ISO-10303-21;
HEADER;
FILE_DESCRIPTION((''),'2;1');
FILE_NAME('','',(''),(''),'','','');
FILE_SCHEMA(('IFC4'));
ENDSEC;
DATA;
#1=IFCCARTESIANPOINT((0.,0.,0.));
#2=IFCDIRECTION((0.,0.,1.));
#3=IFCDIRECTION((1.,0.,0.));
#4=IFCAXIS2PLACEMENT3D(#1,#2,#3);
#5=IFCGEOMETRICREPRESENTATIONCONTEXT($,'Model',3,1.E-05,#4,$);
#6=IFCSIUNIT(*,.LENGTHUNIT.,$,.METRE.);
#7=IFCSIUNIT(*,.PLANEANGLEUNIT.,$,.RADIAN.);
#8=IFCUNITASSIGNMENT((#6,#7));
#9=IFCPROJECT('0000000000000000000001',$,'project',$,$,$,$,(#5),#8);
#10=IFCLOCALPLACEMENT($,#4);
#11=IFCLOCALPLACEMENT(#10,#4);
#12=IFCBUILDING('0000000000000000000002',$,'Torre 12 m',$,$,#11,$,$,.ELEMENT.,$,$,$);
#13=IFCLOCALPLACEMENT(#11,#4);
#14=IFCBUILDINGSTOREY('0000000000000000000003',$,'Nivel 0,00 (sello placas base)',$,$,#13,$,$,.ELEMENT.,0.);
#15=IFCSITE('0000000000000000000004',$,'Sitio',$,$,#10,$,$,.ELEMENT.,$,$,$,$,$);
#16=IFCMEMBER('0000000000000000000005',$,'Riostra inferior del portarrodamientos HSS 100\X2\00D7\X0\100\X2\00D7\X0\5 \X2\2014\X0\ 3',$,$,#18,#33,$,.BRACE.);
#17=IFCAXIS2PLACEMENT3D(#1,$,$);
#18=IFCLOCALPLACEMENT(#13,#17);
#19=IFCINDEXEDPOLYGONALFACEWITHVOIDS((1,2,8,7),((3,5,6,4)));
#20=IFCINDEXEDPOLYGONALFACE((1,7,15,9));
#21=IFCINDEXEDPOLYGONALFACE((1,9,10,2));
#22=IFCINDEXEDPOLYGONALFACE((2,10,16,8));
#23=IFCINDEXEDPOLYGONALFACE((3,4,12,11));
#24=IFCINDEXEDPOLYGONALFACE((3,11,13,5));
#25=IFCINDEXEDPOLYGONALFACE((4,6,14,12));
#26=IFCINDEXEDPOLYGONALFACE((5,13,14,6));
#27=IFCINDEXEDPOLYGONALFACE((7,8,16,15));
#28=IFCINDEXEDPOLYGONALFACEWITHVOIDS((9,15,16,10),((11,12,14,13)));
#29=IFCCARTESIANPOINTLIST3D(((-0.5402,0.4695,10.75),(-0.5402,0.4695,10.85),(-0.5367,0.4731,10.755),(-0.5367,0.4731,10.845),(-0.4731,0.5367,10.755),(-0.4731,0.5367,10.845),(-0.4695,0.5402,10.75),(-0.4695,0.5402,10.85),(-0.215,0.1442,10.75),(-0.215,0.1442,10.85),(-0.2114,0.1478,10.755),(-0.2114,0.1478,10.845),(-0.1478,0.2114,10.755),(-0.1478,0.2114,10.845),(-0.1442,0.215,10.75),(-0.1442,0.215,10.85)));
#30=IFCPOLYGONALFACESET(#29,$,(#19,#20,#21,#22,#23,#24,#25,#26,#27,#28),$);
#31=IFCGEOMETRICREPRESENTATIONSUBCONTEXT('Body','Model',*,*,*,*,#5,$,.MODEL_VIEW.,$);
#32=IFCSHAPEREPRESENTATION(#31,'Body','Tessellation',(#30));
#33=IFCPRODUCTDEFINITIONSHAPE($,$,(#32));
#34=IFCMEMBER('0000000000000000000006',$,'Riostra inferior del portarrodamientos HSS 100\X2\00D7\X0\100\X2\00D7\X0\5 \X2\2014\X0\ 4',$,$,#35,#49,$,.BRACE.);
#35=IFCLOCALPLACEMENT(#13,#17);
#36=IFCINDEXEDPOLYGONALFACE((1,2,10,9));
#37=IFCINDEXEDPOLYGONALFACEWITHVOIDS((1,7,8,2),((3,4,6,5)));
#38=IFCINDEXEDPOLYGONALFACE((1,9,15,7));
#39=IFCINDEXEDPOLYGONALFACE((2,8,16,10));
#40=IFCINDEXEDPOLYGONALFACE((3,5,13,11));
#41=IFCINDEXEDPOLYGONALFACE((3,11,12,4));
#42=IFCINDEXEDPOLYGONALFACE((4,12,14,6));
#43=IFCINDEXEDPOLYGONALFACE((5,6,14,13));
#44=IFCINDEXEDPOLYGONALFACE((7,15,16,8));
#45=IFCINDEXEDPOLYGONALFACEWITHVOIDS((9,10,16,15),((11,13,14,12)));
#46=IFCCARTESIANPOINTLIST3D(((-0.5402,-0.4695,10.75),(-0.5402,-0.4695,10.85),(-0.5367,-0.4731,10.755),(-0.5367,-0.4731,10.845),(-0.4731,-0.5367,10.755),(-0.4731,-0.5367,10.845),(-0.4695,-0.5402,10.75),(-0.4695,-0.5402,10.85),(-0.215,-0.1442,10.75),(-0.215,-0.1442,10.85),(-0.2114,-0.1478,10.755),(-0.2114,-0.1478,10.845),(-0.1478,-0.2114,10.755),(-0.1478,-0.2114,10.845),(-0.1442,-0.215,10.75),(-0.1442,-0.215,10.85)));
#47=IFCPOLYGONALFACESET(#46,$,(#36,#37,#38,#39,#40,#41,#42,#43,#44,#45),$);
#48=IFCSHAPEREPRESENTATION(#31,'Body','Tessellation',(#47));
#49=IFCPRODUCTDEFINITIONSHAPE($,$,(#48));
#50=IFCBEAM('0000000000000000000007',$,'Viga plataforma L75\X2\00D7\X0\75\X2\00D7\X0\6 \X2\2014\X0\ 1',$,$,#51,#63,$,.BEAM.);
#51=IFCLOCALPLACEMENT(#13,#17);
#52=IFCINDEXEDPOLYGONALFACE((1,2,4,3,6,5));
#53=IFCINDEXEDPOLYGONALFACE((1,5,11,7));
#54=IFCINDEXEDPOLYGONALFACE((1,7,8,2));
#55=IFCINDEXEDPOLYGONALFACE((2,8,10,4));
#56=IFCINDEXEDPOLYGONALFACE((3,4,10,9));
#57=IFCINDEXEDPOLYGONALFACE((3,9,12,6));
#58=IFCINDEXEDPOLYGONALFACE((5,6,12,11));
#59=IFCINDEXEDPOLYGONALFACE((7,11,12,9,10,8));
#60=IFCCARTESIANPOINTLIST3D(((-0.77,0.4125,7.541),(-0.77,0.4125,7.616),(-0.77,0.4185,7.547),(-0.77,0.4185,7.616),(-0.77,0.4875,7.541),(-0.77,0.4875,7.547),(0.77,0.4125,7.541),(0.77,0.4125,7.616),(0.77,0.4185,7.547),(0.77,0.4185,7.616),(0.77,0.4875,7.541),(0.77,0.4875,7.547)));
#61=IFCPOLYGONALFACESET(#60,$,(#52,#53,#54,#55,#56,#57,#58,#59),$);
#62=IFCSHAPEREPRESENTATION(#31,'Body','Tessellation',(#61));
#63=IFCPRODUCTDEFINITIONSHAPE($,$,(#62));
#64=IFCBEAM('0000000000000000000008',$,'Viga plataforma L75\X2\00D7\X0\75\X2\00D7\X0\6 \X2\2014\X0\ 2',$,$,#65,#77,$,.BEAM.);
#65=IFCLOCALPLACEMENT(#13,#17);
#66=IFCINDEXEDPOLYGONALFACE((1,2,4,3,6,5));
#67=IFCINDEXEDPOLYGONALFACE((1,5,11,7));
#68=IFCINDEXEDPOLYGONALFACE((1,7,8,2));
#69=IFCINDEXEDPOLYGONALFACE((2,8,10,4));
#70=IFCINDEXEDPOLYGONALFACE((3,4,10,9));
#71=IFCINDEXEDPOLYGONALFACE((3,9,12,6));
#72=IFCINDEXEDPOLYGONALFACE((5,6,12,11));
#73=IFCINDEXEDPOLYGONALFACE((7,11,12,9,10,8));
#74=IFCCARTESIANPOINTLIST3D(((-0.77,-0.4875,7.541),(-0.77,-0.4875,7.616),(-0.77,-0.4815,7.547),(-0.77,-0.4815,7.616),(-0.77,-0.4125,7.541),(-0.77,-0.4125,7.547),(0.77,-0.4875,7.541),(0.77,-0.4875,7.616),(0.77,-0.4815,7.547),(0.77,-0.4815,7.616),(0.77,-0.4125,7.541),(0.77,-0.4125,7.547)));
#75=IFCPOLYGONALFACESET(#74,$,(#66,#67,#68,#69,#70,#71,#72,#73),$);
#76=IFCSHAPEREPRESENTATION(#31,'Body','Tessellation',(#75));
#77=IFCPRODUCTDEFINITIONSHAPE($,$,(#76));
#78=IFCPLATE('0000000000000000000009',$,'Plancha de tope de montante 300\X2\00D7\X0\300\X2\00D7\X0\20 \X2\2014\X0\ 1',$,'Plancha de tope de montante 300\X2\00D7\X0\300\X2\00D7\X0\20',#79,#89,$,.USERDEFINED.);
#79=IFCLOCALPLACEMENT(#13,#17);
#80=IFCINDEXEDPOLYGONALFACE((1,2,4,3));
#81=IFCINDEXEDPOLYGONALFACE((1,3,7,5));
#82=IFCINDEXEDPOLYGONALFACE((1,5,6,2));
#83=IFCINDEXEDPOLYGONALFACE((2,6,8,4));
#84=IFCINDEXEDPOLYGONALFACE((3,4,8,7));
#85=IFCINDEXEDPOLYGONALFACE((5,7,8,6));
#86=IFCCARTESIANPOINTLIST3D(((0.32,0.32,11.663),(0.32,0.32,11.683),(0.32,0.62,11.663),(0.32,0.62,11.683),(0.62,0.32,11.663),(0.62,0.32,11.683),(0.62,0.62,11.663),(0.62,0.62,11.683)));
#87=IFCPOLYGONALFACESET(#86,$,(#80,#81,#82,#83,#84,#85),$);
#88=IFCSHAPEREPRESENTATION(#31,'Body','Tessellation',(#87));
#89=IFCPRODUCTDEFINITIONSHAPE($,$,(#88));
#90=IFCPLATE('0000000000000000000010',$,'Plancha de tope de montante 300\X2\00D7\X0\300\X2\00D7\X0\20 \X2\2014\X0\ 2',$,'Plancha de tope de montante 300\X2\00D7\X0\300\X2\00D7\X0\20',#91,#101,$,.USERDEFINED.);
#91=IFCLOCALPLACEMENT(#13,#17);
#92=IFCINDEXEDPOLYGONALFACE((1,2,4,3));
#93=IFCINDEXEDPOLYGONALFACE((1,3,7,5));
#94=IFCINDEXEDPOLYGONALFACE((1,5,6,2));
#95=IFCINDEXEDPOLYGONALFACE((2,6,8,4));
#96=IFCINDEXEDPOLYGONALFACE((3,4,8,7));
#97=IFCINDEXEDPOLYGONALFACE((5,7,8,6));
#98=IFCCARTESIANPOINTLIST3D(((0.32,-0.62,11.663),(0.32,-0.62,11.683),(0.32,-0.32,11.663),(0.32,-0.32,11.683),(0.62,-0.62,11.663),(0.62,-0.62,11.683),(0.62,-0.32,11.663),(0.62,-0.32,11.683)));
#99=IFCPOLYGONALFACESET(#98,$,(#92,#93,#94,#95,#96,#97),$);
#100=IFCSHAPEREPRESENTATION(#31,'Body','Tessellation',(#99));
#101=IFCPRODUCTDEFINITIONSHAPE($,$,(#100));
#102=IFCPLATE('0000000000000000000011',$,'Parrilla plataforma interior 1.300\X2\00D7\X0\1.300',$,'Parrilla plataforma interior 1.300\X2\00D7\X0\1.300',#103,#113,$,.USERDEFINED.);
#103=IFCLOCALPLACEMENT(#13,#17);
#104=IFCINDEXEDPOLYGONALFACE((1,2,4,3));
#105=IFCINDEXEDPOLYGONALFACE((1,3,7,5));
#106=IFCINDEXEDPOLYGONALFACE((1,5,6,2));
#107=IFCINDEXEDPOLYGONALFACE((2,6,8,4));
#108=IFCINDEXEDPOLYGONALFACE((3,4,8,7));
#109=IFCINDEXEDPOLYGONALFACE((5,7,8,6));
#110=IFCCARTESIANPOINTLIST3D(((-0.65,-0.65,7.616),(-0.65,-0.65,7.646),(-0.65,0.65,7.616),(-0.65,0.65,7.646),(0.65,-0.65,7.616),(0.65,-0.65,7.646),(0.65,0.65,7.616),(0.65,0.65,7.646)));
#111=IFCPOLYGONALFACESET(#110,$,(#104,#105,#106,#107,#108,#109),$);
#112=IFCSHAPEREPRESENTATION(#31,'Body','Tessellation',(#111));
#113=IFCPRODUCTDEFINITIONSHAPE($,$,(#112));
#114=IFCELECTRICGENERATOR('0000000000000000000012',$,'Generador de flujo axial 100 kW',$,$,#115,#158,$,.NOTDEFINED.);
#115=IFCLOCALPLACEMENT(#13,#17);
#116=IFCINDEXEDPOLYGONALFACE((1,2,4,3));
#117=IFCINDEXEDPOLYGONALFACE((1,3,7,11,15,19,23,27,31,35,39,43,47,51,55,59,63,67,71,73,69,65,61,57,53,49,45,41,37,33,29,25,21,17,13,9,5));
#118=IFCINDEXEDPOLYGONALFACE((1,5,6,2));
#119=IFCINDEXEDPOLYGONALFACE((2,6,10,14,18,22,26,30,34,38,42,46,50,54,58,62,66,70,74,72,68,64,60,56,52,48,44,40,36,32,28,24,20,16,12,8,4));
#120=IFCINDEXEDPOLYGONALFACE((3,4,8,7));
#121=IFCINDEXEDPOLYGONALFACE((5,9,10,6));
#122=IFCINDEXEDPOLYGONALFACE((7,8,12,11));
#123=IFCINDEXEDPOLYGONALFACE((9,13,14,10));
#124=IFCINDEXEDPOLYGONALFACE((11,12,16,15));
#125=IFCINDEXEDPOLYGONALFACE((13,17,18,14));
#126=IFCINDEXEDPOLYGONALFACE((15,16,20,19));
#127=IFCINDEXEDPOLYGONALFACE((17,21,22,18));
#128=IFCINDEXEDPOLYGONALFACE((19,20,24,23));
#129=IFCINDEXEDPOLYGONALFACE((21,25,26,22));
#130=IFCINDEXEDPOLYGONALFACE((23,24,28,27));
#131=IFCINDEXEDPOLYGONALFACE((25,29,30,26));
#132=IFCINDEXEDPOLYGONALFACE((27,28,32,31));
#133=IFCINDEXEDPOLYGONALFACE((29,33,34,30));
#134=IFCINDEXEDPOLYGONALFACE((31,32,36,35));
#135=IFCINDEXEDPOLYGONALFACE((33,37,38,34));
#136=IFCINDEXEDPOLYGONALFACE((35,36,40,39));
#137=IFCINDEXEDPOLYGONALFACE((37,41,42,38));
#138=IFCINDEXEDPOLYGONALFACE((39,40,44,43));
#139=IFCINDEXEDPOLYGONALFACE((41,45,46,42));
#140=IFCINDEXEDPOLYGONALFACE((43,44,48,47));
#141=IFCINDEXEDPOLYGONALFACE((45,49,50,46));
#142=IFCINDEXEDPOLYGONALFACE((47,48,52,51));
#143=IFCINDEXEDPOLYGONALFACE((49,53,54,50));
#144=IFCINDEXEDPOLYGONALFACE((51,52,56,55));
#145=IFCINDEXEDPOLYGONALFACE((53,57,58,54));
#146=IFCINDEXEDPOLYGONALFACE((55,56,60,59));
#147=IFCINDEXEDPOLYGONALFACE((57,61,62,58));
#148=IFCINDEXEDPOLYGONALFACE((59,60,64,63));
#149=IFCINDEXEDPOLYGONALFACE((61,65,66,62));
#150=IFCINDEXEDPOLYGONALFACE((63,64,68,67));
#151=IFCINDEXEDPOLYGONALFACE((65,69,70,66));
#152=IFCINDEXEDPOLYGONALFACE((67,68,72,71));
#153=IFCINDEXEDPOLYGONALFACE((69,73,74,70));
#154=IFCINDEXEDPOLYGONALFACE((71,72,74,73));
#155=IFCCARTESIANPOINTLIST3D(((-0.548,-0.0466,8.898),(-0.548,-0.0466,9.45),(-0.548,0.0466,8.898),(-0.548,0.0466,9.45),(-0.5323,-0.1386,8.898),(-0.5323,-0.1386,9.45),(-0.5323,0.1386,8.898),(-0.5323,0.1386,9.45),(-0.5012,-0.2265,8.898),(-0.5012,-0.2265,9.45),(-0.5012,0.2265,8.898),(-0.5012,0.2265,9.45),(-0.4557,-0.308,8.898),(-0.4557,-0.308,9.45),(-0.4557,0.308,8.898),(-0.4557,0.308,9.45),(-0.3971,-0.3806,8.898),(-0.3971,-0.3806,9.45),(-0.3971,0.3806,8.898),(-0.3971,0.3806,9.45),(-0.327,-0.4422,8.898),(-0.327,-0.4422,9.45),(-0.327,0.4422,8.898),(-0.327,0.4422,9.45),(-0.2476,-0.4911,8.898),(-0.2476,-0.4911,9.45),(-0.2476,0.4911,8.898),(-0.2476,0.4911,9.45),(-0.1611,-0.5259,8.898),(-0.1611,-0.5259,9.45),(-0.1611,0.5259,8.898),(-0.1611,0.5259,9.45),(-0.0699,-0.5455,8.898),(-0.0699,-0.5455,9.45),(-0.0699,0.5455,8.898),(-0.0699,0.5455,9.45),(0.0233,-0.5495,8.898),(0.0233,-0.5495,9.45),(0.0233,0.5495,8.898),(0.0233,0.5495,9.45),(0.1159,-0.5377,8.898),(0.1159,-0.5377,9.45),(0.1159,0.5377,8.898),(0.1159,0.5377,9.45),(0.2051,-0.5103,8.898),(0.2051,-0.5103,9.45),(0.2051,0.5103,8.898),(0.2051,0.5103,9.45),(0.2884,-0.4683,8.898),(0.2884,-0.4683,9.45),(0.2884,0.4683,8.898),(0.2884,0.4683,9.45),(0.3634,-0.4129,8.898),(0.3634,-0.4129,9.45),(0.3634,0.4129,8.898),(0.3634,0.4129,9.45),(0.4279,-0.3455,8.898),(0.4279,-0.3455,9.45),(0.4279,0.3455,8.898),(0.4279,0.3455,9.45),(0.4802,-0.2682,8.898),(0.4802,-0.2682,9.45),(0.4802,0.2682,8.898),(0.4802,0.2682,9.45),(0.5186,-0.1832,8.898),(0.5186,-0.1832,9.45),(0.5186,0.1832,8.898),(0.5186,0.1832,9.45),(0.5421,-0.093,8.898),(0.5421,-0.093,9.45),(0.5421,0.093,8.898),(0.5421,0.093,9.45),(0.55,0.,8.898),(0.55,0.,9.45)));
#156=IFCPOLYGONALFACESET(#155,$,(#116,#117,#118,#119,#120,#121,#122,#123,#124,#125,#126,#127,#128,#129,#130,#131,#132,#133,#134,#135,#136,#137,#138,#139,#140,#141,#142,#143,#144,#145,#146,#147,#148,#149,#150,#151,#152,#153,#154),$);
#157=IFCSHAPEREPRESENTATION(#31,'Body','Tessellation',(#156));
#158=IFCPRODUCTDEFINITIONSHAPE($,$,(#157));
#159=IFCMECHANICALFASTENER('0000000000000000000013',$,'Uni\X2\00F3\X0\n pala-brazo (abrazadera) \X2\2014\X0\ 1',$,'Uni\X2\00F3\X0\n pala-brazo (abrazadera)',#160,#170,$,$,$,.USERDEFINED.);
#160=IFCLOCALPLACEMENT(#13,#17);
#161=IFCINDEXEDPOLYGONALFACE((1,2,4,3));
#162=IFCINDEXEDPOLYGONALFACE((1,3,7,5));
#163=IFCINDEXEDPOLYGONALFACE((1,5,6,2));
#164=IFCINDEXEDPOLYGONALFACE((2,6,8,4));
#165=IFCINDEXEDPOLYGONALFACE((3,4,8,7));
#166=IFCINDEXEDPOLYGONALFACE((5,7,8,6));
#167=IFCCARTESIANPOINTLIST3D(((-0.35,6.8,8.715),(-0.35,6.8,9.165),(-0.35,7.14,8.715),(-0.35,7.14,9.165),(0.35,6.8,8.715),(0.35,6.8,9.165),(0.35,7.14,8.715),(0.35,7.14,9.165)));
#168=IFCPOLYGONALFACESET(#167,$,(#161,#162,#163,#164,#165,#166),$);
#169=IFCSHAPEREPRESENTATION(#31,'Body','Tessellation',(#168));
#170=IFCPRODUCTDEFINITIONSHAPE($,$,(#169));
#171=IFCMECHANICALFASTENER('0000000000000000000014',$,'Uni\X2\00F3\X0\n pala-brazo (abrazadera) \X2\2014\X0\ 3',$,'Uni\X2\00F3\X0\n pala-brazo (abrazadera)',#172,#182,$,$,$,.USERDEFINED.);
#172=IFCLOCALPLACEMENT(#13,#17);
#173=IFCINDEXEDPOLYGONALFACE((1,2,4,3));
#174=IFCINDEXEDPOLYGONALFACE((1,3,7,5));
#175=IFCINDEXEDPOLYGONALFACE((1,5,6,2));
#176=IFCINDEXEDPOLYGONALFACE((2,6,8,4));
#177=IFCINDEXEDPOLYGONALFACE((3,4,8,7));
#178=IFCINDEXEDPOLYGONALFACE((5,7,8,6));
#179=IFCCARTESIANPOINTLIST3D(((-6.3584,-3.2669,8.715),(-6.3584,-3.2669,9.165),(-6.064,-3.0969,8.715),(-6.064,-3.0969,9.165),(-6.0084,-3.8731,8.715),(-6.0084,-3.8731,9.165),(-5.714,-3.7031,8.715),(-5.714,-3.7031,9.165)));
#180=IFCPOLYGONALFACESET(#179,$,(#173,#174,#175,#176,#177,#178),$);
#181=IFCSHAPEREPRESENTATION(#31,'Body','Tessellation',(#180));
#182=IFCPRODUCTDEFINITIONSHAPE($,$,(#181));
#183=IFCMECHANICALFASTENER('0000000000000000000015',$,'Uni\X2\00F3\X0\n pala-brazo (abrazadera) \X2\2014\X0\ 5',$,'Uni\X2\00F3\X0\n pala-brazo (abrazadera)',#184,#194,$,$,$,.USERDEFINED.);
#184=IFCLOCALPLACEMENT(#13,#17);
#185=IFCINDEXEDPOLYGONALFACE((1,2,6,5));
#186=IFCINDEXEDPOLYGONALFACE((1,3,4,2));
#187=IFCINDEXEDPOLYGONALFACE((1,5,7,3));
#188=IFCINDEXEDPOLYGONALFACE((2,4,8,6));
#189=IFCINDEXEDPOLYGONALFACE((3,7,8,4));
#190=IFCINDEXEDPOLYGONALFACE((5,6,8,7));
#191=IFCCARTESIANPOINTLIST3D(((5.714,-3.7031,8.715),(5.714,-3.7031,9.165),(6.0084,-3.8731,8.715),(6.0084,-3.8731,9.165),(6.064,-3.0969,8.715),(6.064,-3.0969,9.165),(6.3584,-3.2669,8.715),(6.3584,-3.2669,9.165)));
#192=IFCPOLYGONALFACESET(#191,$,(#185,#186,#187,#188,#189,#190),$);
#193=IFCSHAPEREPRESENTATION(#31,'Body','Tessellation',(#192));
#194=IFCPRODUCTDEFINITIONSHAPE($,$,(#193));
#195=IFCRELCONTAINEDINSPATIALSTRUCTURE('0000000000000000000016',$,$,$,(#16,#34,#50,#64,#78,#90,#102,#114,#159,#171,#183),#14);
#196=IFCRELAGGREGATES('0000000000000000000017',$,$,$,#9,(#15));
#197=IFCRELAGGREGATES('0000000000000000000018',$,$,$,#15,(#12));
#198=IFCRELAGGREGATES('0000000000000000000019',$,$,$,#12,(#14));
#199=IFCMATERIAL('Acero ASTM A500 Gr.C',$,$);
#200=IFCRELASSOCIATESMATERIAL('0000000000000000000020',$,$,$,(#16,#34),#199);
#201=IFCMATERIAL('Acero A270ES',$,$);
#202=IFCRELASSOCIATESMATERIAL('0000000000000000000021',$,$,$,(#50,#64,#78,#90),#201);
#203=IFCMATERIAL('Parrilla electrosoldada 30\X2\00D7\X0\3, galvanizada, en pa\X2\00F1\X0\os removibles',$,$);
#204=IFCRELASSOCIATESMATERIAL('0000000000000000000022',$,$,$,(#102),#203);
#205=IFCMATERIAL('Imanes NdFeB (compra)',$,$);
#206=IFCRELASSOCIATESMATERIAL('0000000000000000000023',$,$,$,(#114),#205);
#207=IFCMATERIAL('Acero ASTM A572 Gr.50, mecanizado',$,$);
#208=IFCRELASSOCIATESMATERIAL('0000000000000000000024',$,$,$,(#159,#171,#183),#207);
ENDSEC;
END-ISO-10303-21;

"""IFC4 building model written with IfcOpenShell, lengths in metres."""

from ifc_helpers import new_model, si_unit, frame, origin, origin_with_axes, origin_2d, place, context, subcontext, project, spatial, rectangle, hollow_rectangle, circle, l_section, extrude, material, element, save


model = new_model("IFC4")

# Units and contexts
model_context = context("Model", 3, precision=1e-05, world=origin_with_axes())
body_context = subcontext(model_context, "Body", "Model", "MODEL_VIEW")
ifc_project = project(units=[si_unit("LENGTHUNIT", "METRE"), si_unit("PLANEANGLEUNIT", "RADIAN")], contexts=[model_context])

# Site, building, storey
site_placement = place(None, origin_with_axes())
site = spatial("IfcSite", under=ifc_project, at=site_placement, Name="Sitio", CompositionType="ELEMENT")
building_placement = place(site_placement, origin_with_axes())
building = spatial("IfcBuilding", under=site, at=building_placement, Name="Torre 12 m", CompositionType="ELEMENT")
storey_placement = place(building_placement, origin_with_axes())
storey = spatial("IfcBuildingStorey", under=building, at=storey_placement, Name="Nivel 0,00 (sello placas base)", CompositionType="ELEMENT", Elevation=0.0)

# Members
ifc_material_1 = material(Name="Acero ASTM A500 Gr.C")
for number, where, z_axis, x_axis, name in (
    (1, (-0.1796, 0.1796, 10.8), (-0.707107, 0.707107, 0.0), (0.0, 0.0, 1.0), "Riostra inferior del portarrodamientos HSS 100×100×5 — 3"),
    (2, (-0.1796, -0.1796, 10.8), (-0.707107, -0.707107, 0.0), (0.0, 0.0, 1.0), "Riostra inferior del portarrodamientos HSS 100×100×5 — 4"),
):
    element("IfcMember", number, at=place(storey_placement, frame(where, z_axis=z_axis, x_axis=x_axis)), inside=storey, material=ifc_material_1, Name=name, PredefinedType="BRACE", context=body_context, shape_type="SweptSolid", body=[
        extrude(hollow_rectangle(XDim=0.1, YDim=0.1, WallThickness=0.005, at=origin_2d()), origin(), (0.0, 0.0, 1.0), 0.46),
    ])

# Beams
ifc_material_2 = material(Name="Acero A270ES")
for number, where, z_axis, x_axis, name in (
    (3, (-0.77, 0.45, 7.5785), (1.0, 0.0, 0.0), (0.0, 1.0, 0.0), "Viga plataforma L75×75×6 — 1"),
    (4, (-0.77, -0.45, 7.5785), (1.0, 0.0, 0.0), (0.0, 1.0, 0.0), "Viga plataforma L75×75×6 — 2"),
):
    element("IfcBeam", number, at=place(storey_placement, frame(where, z_axis=z_axis, x_axis=x_axis)), inside=storey, material=ifc_material_2, Name=name, PredefinedType="BEAM", context=body_context, shape_type="SweptSolid", body=[
        extrude(l_section(Depth=0.075, Width=0.075, Thickness=0.006, at=origin_2d()), origin(), (0.0, 0.0, 1.0), 1.54),
    ])

# Plates
for number, where, z_axis, x_axis, name in (
    (5, (0.47, 0.47, 11.663), (0.0, 0.0, 1.0), (1.0, 0.0, 0.0), "Plancha de tope de montante 300×300×20 — 1"),
    (6, (0.47, -0.47, 11.663), (0.0, 0.0, 1.0), (1.0, 0.0, 0.0), "Plancha de tope de montante 300×300×20 — 2"),
):
    element("IfcPlate", number, at=place(storey_placement, frame(where, z_axis=z_axis, x_axis=x_axis)), inside=storey, material=ifc_material_2, Name=name, ObjectType="Plancha de tope de montante 300×300×20", PredefinedType="USERDEFINED", context=body_context, shape_type="SweptSolid", body=[
        extrude(rectangle(XDim=0.3, YDim=0.3, at=origin_2d()), origin(), (0.0, 0.0, 1.0), 0.02),
    ])
ifc_material_3 = material(Name="Parrilla electrosoldada 30×3, galvanizada, en paños removibles")
plate_placement = place(storey_placement, frame((0.0, 0.0, 7.616), z_axis=(0.0, 0.0, 1.0), x_axis=(1.0, 0.0, 0.0)))
element("IfcPlate", 7, at=plate_placement, inside=storey, material=ifc_material_3, Name="Parrilla plataforma interior 1.300×1.300", ObjectType="Parrilla plataforma interior 1.300×1.300", PredefinedType="USERDEFINED", context=body_context, shape_type="SweptSolid", body=[
    extrude(rectangle(XDim=1.3, YDim=1.3, at=origin_2d()), origin(), (0.0, 0.0, 1.0), 0.03),
])

# Electric generator
ifc_material_4 = material(Name="Imanes NdFeB (compra)")
electric_generator_placement = place(storey_placement, frame((0.0, 0.0, 8.898), z_axis=(0.0, 0.0, 1.0), x_axis=(1.0, 0.0, 0.0)))
element("IfcElectricGenerator", 8, at=electric_generator_placement, inside=storey, material=ifc_material_4, Name="Generador de flujo axial 100 kW", PredefinedType="NOTDEFINED", context=body_context, shape_type="SweptSolid", body=[
    extrude(circle(Radius=0.55, at=origin_2d()), origin(), (0.0, 0.0, 1.0), 0.552),
])

# Mechanical fasteners
ifc_material_5 = material(Name="Acero ASTM A572 Gr.50, mecanizado")
for number, where, z_axis, x_axis, name in (
    (9, (0.0, 6.97, 8.715), (0.0, 0.0, 1.0), (-1.0, 0.0, 0.0), "Unión pala-brazo (abrazadera) — 1"),
    (10, (-6.0362, -3.485, 8.715), (0.0, 0.0, 1.0), (0.5, -0.866025, 0.0), "Unión pala-brazo (abrazadera) — 3"),
    (11, (6.0362, -3.485, 8.715), (0.0, 0.0, 1.0), (0.5, 0.866025, 0.0), "Unión pala-brazo (abrazadera) — 5"),
):
    element("IfcMechanicalFastener", number, at=place(storey_placement, frame(where, z_axis=z_axis, x_axis=x_axis)), inside=storey, material=ifc_material_5, Name=name, ObjectType="Unión pala-brazo (abrazadera)", PredefinedType="USERDEFINED", context=body_context, shape_type="SweptSolid", body=[
        extrude(rectangle(XDim=0.7, YDim=0.34, at=origin_2d()), origin(), (0.0, 0.0, 1.0), 0.45),
    ])

save(model, "model.ifc")
